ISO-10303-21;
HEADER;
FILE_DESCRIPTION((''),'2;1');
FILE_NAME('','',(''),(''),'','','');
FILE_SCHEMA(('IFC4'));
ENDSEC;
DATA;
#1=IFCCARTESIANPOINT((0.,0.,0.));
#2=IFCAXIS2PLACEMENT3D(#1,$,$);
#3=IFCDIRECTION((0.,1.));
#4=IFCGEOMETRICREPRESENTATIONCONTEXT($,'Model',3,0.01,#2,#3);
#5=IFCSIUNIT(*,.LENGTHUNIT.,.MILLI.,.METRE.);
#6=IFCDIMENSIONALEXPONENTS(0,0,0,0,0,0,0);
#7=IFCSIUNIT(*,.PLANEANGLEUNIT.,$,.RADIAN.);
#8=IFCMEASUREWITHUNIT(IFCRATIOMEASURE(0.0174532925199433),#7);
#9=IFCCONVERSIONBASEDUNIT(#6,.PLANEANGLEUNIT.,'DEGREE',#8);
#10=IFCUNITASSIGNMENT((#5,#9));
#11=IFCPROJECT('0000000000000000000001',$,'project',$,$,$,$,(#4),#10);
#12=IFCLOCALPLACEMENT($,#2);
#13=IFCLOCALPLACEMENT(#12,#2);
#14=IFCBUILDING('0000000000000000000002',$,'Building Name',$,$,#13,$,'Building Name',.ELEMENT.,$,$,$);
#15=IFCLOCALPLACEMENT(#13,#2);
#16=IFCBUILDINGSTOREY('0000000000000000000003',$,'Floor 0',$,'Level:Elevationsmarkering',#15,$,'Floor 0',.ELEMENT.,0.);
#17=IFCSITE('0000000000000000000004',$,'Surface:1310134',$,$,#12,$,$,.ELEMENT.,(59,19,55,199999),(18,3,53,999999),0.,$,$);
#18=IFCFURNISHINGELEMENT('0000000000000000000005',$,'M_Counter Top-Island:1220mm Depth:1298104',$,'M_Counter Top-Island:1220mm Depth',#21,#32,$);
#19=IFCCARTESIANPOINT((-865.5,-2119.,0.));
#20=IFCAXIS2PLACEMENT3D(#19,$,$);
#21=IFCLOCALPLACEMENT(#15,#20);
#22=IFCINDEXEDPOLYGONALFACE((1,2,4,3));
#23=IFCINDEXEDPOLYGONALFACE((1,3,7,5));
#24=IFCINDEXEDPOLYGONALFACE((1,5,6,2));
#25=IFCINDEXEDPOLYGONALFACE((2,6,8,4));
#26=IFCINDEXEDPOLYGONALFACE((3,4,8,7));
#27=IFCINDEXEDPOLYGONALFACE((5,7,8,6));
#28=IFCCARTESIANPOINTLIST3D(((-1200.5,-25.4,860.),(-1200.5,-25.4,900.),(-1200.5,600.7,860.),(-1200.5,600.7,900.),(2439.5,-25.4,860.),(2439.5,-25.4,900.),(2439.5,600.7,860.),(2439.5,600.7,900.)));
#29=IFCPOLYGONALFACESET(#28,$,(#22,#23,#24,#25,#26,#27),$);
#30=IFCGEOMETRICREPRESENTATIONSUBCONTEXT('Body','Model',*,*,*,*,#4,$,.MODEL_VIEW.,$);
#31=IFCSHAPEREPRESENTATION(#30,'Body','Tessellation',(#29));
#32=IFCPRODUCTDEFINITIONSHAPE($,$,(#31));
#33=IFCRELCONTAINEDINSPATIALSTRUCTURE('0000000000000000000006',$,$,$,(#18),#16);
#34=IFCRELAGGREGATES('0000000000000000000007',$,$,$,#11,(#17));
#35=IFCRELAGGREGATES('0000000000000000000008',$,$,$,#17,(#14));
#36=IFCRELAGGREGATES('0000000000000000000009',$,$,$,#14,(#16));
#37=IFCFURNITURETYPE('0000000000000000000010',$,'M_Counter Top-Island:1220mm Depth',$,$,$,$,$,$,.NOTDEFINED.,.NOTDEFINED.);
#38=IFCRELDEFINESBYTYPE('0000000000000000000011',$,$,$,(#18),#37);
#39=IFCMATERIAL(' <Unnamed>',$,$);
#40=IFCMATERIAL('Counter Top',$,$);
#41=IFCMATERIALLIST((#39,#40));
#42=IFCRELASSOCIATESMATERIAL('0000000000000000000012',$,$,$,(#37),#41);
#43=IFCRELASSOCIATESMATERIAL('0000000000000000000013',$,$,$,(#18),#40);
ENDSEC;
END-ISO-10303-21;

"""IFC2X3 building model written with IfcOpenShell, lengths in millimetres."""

from ifc_helpers import new_model, entity, si_unit, converted_unit, direction, frame, frame_2d, origin, place, context, subcontext, project, spatial, rectangle, extrude, source, transform, mapped, material, material_list, type_object, type_shapes, element, save


model = new_model("IFC2X3")

# Units and contexts
model_context = context("Model", 3, precision=0.01, world=origin(), true_north=direction((0.0, 1.0)))
body_context = subcontext(model_context, "Body", "Model", "MODEL_VIEW")
ifc_project = project(units=[si_unit("LENGTHUNIT", "METRE", prefix="MILLI"), converted_unit("PLANEANGLEUNIT", "DEGREE", entity("IfcRatioMeasure", 0.0174532925199433), si_unit("PLANEANGLEUNIT", "RADIAN"), dimensions=[0, 0, 0, 0, 0, 0, 0])], contexts=[model_context])

# Site, building, storey
site_placement = place(None, origin())
site = spatial("IfcSite", under=ifc_project, at=site_placement, Name="Surface:1310134", CompositionType="ELEMENT", RefLatitude=(59, 19, 55, 199999), RefLongitude=(18, 3, 53, 999999), RefElevation=0.0)
building_placement = place(site_placement, origin())
building = spatial("IfcBuilding", under=site, at=building_placement, Name="Building Name", LongName="Building Name", CompositionType="ELEMENT")
storey_placement = place(building_placement, origin())
storey = spatial("IfcBuildingStorey", under=building, at=storey_placement, Name="Floor 0", ObjectType="Level:Elevationsmarkering", LongName="Floor 0", CompositionType="ELEMENT", Elevation=0.0)

# Shared definitions
ifc_material_1 = material(Name="Counter Top")
ifc_material_2 = material(Name=" <Unnamed>")

# Furnishing element
ifc_material_list_1 = material_list([ifc_material_2, ifc_material_1])
furniture_type_1 = type_object("IfcFurnitureType", Name="M_Counter Top-Island:1220mm Depth", material=ifc_material_list_1)
shared_shape_1 = source(origin(), body_context, "Body", "SweptSolid", [
    extrude(rectangle(XDim=626.1, YDim=3640.0, at=frame_2d((0.0, 0.0), x_axis=(1.0, 0.0))), frame((619.5, 287.6, 860.0), z_axis=(0.0, 0.0, 1.0), x_axis=(0.0, 1.0, 0.0)), (0.0, 0.0, 1.0), 40.0),
])
type_shapes(furniture_type_1, [shared_shape_1])
furnishing_1_placement = place(storey_placement, frame((-865.5, -2119.0, 0.0)))
element("IfcFurnishingElement", 1, at=furnishing_1_placement, inside=storey, type_object=furniture_type_1, material=ifc_material_1, Name="M_Counter Top-Island:1220mm Depth:1298104", ObjectType="M_Counter Top-Island:1220mm Depth", context=body_context, shape_type="MappedRepresentation", body=[
    mapped(shared_shape_1, transform((0.0, 0.0, 0.0), scale=1.0)),
])

save(model, "model.ifc")
